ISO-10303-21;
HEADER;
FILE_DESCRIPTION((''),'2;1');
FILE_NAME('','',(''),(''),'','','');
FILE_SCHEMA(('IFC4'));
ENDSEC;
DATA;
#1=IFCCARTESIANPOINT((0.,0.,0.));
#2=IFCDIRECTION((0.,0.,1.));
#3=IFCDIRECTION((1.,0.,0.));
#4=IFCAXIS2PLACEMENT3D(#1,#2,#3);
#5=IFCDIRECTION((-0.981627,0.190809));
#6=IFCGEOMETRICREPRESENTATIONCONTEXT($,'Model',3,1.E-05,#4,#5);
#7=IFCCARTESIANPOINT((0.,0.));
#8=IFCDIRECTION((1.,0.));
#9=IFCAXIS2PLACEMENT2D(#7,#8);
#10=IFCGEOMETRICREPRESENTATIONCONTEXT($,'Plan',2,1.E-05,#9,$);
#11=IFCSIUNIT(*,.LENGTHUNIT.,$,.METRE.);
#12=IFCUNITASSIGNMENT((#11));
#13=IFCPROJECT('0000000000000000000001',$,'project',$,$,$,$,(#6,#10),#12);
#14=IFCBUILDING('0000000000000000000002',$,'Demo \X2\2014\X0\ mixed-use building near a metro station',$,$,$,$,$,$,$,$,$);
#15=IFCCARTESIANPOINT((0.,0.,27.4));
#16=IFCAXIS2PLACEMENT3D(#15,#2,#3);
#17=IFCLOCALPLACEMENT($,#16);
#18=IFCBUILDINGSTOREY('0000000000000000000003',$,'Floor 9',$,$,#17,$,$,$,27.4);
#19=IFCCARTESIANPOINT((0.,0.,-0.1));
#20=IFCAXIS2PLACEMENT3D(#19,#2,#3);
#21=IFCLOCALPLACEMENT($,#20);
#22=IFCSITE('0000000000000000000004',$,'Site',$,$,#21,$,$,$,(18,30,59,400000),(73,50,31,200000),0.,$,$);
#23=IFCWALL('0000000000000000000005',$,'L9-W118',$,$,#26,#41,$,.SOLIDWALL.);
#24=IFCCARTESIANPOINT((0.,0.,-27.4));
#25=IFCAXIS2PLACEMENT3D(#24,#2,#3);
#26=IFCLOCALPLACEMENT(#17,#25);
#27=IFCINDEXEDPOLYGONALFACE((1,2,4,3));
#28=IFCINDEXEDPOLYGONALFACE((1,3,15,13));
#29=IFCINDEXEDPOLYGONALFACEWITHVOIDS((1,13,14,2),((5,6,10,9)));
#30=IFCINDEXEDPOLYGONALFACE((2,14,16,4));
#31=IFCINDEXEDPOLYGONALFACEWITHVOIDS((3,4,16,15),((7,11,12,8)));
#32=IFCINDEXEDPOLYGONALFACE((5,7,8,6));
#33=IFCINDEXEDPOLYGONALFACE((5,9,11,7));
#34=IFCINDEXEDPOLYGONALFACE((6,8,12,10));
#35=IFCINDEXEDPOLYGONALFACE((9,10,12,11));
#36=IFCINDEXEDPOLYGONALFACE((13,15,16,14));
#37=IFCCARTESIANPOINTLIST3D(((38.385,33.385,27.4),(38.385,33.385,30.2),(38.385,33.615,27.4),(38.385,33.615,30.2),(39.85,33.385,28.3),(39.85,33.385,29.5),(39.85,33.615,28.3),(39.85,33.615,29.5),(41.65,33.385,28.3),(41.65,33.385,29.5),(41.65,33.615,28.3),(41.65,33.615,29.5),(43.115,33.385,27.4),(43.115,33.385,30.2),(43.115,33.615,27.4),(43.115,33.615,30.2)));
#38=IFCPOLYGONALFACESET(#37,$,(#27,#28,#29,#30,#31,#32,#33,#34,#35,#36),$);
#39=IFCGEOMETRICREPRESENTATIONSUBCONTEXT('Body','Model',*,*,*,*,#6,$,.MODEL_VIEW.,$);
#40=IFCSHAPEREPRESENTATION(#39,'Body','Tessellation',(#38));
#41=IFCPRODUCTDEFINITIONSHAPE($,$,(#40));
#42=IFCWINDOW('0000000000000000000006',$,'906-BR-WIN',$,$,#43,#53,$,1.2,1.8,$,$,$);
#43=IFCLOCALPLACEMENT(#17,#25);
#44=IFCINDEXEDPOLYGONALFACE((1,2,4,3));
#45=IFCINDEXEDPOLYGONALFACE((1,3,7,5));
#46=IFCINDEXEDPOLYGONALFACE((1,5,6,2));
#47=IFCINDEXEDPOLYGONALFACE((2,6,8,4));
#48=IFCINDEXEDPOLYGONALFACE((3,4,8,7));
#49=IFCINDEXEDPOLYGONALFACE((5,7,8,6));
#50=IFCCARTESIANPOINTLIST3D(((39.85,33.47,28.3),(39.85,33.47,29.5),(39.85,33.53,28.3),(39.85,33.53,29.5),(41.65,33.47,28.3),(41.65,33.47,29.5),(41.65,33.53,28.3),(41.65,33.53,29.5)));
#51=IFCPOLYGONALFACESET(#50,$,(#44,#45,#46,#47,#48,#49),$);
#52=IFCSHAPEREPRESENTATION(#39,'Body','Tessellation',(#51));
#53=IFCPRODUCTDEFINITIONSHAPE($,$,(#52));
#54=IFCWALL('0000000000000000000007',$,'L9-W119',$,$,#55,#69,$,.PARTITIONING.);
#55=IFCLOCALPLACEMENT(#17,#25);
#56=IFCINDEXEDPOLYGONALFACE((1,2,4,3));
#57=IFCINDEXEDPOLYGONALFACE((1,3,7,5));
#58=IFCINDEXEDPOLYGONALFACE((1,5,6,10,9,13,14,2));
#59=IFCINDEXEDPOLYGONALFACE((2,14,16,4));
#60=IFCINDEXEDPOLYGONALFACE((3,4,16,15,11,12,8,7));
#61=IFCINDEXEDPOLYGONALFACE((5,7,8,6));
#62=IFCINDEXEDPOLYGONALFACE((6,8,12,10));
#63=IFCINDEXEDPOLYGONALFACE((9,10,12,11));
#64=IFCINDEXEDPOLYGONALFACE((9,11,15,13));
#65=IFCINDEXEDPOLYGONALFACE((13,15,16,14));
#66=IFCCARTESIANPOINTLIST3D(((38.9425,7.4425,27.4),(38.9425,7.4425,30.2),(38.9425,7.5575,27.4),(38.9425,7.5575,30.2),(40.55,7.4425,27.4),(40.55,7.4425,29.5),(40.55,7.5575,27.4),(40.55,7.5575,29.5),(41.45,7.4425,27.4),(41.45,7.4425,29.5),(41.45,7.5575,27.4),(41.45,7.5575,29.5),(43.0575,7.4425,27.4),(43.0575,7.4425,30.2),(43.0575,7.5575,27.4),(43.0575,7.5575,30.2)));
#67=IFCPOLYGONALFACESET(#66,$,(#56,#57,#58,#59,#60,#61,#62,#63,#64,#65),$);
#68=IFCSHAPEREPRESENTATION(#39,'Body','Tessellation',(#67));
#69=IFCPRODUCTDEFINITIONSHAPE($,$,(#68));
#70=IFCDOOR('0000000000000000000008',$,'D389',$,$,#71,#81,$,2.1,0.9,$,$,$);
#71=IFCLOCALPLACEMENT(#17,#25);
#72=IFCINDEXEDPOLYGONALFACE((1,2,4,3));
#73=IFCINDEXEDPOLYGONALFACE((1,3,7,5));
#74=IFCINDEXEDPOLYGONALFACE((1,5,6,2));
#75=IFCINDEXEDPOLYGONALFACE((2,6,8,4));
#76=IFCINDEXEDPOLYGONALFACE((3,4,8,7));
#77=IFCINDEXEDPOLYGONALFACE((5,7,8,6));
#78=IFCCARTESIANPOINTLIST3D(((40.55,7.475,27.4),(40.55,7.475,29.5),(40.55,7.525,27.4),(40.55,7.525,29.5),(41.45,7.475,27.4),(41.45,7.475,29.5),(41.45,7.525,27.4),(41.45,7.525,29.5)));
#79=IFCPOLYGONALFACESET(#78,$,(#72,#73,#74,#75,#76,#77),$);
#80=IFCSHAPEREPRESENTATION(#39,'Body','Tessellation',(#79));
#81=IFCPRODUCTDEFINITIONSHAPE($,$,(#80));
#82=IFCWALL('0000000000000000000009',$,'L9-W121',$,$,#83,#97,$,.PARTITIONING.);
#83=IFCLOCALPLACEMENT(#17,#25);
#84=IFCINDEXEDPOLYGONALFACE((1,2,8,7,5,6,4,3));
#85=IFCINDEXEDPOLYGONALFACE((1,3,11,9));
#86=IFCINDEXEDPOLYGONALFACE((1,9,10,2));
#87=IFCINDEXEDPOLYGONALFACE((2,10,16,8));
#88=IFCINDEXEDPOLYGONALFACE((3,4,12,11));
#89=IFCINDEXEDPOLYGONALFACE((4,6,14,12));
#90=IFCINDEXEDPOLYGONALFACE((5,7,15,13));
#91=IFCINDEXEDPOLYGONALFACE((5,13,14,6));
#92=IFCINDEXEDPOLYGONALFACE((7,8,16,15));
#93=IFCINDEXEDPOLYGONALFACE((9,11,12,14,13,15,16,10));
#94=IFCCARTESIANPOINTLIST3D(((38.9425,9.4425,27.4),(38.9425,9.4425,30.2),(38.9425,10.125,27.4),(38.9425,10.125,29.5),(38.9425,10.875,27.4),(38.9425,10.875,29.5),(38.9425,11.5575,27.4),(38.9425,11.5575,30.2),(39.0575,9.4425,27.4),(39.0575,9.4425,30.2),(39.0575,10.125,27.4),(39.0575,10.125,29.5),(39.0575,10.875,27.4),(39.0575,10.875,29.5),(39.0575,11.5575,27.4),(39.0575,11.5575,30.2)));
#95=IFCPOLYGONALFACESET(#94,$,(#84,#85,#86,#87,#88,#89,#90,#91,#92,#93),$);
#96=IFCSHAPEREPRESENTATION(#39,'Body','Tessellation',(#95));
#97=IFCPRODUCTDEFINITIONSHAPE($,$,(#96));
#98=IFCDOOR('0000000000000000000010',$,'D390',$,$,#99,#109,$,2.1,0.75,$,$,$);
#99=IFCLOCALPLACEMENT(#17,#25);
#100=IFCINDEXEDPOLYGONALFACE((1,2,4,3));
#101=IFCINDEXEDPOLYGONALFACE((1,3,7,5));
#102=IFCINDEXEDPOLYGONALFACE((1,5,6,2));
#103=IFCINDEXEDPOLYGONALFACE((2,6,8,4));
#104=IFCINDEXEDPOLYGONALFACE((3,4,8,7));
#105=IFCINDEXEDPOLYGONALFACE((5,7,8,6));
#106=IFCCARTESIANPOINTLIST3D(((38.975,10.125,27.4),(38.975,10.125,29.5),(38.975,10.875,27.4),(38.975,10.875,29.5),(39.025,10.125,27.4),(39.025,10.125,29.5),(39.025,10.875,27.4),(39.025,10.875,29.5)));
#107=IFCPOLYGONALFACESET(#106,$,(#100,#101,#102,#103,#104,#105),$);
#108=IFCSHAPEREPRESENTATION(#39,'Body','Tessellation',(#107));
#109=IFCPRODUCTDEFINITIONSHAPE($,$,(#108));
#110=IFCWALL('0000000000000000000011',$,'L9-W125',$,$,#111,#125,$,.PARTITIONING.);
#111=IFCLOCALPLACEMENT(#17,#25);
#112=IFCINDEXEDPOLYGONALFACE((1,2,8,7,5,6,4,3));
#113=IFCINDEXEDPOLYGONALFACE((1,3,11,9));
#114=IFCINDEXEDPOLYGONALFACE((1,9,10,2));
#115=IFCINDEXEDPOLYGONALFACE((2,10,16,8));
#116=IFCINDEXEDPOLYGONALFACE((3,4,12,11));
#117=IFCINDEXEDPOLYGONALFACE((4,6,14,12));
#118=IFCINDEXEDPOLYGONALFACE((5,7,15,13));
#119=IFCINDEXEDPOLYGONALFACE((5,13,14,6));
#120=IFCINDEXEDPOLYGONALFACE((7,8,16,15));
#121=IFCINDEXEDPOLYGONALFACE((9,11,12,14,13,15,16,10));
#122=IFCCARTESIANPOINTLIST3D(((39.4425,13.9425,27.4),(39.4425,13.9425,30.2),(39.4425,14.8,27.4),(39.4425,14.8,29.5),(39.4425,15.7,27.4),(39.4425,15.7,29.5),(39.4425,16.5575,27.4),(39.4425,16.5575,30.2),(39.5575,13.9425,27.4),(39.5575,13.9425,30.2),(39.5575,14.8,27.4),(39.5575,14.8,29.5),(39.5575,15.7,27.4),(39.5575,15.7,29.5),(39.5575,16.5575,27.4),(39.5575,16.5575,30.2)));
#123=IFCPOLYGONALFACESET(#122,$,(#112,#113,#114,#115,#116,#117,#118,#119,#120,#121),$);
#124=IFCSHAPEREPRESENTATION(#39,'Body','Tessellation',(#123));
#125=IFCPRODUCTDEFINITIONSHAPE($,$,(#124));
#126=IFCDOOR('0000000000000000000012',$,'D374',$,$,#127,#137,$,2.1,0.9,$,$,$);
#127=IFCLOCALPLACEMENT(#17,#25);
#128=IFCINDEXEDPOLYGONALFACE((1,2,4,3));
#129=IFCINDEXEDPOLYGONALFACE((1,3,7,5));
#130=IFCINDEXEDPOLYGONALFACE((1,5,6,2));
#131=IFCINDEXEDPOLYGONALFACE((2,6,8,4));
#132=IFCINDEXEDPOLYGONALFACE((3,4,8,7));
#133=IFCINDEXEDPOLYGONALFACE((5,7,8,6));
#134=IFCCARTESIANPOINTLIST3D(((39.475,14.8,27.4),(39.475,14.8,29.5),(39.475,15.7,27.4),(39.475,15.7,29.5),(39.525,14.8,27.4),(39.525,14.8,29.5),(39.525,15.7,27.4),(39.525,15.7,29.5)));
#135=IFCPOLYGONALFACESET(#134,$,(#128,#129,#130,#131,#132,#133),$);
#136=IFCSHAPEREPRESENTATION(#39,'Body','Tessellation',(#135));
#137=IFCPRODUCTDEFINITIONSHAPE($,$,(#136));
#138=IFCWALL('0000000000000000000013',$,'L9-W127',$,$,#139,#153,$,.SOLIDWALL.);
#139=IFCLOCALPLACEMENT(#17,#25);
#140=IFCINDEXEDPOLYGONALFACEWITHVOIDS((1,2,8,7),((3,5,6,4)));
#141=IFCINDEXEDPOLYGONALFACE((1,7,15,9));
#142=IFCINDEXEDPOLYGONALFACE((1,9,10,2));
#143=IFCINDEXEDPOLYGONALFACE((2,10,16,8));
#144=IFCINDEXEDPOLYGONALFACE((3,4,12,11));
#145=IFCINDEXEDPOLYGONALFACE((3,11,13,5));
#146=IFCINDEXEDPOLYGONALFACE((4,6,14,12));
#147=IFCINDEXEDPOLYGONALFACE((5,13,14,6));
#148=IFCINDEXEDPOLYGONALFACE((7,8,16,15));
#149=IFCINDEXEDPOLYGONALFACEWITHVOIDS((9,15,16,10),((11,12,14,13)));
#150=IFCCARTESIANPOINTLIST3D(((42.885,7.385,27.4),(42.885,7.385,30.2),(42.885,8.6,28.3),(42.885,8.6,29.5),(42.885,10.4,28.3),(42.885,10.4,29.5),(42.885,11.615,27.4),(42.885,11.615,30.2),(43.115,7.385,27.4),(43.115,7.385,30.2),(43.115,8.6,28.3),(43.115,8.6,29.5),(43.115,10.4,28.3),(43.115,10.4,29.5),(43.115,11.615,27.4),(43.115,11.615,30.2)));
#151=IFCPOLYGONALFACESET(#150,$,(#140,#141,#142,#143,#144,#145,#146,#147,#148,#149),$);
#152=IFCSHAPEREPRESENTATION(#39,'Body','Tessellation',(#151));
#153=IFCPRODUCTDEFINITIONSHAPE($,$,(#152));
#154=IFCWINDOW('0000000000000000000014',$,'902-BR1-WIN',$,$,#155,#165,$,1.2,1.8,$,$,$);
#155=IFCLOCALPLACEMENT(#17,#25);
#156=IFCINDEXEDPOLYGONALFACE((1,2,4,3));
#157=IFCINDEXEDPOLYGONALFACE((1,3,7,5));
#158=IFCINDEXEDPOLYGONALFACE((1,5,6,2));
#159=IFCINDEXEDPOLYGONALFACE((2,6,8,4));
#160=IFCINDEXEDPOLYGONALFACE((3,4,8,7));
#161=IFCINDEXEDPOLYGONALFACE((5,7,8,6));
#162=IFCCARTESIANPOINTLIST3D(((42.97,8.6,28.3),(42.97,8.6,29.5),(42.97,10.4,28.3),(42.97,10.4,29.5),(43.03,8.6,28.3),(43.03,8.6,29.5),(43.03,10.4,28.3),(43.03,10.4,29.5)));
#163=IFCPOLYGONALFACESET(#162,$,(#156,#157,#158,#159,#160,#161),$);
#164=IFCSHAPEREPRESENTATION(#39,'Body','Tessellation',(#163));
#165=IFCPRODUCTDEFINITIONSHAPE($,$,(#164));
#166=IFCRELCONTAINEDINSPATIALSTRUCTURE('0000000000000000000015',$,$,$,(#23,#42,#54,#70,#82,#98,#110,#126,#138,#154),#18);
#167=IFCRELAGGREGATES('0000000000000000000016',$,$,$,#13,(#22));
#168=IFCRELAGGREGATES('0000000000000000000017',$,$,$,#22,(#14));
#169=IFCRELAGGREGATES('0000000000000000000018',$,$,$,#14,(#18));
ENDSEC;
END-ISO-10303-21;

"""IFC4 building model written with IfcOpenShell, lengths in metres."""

from ifc_helpers import new_model, si_unit, direction, frame, origin_with_axes, origin_2d_with_axis, place, context, subcontext, project, spatial, line, indexed_curve, outline, extrude, element, fill, save


model = new_model("IFC4")

# Units and contexts
model_context = context("Model", 3, precision=1e-05, world=origin_with_axes(), true_north=direction((-0.981627, 0.190809)))
plan_context = context("Plan", 2, precision=1e-05, world=origin_2d_with_axis())
body_context = subcontext(model_context, "Body", "Model", "MODEL_VIEW")
ifc_project = project(units=[si_unit("LENGTHUNIT", "METRE")], contexts=[model_context, plan_context])

# Site, building, storey
site_placement = place(None, frame((0.0, 0.0, -0.1), z_axis=(0.0, 0.0, 1.0), x_axis=(1.0, 0.0, 0.0)))
site = spatial("IfcSite", under=ifc_project, at=site_placement, Name="Site", RefLatitude=(18, 30, 59, 400000), RefLongitude=(73, 50, 31, 200000), RefElevation=0.0)
building = spatial("IfcBuilding", under=site, Name="Demo — mixed-use building near a metro station")
storey_placement = place(None, frame((0.0, 0.0, 27.4), z_axis=(0.0, 0.0, 1.0), x_axis=(1.0, 0.0, 0.0)))
storey = spatial("IfcBuildingStorey", under=building, at=storey_placement, Name="Floor 9", Elevation=27.4)

# Wall, opening, window
wall_1_placement = place(storey_placement, frame((0.0, 0.0, -27.4), z_axis=(0.0, 0.0, 1.0), x_axis=(1.0, 0.0, 0.0)))
wall_1 = element("IfcWall", 1, at=wall_1_placement, inside=storey, Name="L9-W118", PredefinedType="SOLIDWALL", context=body_context, shape_type="SweptSolid", body=[
    extrude(outline(indexed_curve([(43.115, 33.385), (38.385, 33.385), (38.385, 33.615), (43.115, 33.615)], segments=[line(1, 2, 3, 4, 1)])), frame((0.0, 0.0, 27.4), z_axis=(0.0, 0.0, 1.0), x_axis=(1.0, 0.0, 0.0)), (0.0, 0.0, 1.0), 2.8),
])
opening_1_placement = place(wall_1_placement, origin_with_axes())
opening_1 = element("IfcOpeningElement", 2, at=opening_1_placement, cuts=wall_1, context=body_context, shape_type="SweptSolid", body=[
    extrude(outline(indexed_curve([(41.65, 33.335), (39.85, 33.335), (39.85, 33.665), (41.65, 33.665)], segments=[line(1, 2, 3, 4, 1)])), frame((0.0, 0.0, 28.3), z_axis=(0.0, 0.0, 1.0), x_axis=(1.0, 0.0, 0.0)), (0.0, 0.0, 1.0), 1.2),
])
window_1_placement = place(storey_placement, frame((0.0, 0.0, -27.4), z_axis=(0.0, 0.0, 1.0), x_axis=(1.0, 0.0, 0.0)))
window_1 = element("IfcWindow", 3, at=window_1_placement, inside=storey, Name="906-BR-WIN", OverallHeight=1.2, OverallWidth=1.8, context=body_context, shape_type="SweptSolid", body=[
    extrude(outline(indexed_curve([(41.65, 33.47), (39.85, 33.47), (39.85, 33.53), (41.65, 33.53)], segments=[line(1, 2, 3, 4, 1)])), frame((0.0, 0.0, 28.3), z_axis=(0.0, 0.0, 1.0), x_axis=(1.0, 0.0, 0.0)), (0.0, 0.0, 1.0), 1.2),
])
fill(opening_1, window_1)

# Wall, opening, door
wall_2_placement = place(storey_placement, frame((0.0, 0.0, -27.4), z_axis=(0.0, 0.0, 1.0), x_axis=(1.0, 0.0, 0.0)))
wall_2 = element("IfcWall", 4, at=wall_2_placement, inside=storey, Name="L9-W119", PredefinedType="PARTITIONING", context=body_context, shape_type="SweptSolid", body=[
    extrude(outline(indexed_curve([(43.0575, 7.4425), (38.9425, 7.4425), (38.9425, 7.5575), (43.0575, 7.5575)], segments=[line(1, 2, 3, 4, 1)])), frame((0.0, 0.0, 27.4), z_axis=(0.0, 0.0, 1.0), x_axis=(1.0, 0.0, 0.0)), (0.0, 0.0, 1.0), 2.8),
])
opening_2_placement = place(wall_2_placement, origin_with_axes())
opening_2 = element("IfcOpeningElement", 5, at=opening_2_placement, cuts=wall_2, context=body_context, shape_type="SweptSolid", body=[
    extrude(outline(indexed_curve([(41.45, 7.3925), (40.55, 7.3925), (40.55, 7.6075), (41.45, 7.6075)], segments=[line(1, 2, 3, 4, 1)])), frame((0.0, 0.0, 27.4), z_axis=(0.0, 0.0, 1.0), x_axis=(1.0, 0.0, 0.0)), (0.0, 0.0, 1.0), 2.1),
])
door_1_placement = place(storey_placement, frame((0.0, 0.0, -27.4), z_axis=(0.0, 0.0, 1.0), x_axis=(1.0, 0.0, 0.0)))
door_1 = element("IfcDoor", 6, at=door_1_placement, inside=storey, Name="D389", OverallHeight=2.1, OverallWidth=0.9, context=body_context, shape_type="SweptSolid", body=[
    extrude(outline(indexed_curve([(41.45, 7.475), (40.55, 7.475), (40.55, 7.525), (41.45, 7.525)], segments=[line(1, 2, 3, 4, 1)])), frame((0.0, 0.0, 27.4), z_axis=(0.0, 0.0, 1.0), x_axis=(1.0, 0.0, 0.0)), (0.0, 0.0, 1.0), 2.1),
])
fill(opening_2, door_1)

# Wall, opening, door
wall_3_placement = place(storey_placement, frame((0.0, 0.0, -27.4), z_axis=(0.0, 0.0, 1.0), x_axis=(1.0, 0.0, 0.0)))
wall_3 = element("IfcWall", 7, at=wall_3_placement, inside=storey, Name="L9-W121", PredefinedType="PARTITIONING", context=body_context, shape_type="SweptSolid", body=[
    extrude(outline(indexed_curve([(39.0575, 11.5575), (39.0575, 9.4425), (38.9425, 9.4425), (38.9425, 11.5575)], segments=[line(1, 2, 3, 4, 1)])), frame((0.0, 0.0, 27.4), z_axis=(0.0, 0.0, 1.0), x_axis=(1.0, 0.0, 0.0)), (0.0, 0.0, 1.0), 2.8),
])
opening_3_placement = place(wall_3_placement, origin_with_axes())
opening_3 = element("IfcOpeningElement", 8, at=opening_3_placement, cuts=wall_3, context=body_context, shape_type="SweptSolid", body=[
    extrude(outline(indexed_curve([(39.1075, 10.875), (39.1075, 10.125), (38.8925, 10.125), (38.8925, 10.875)], segments=[line(1, 2, 3, 4, 1)])), frame((0.0, 0.0, 27.4), z_axis=(0.0, 0.0, 1.0), x_axis=(1.0, 0.0, 0.0)), (0.0, 0.0, 1.0), 2.1),
])
door_2_placement = place(storey_placement, frame((0.0, 0.0, -27.4), z_axis=(0.0, 0.0, 1.0), x_axis=(1.0, 0.0, 0.0)))
door_2 = element("IfcDoor", 9, at=door_2_placement, inside=storey, Name="D390", OverallHeight=2.1, OverallWidth=0.75, context=body_context, shape_type="SweptSolid", body=[
    extrude(outline(indexed_curve([(39.025, 10.875), (39.025, 10.125), (38.975, 10.125), (38.975, 10.875)], segments=[line(1, 2, 3, 4, 1)])), frame((0.0, 0.0, 27.4), z_axis=(0.0, 0.0, 1.0), x_axis=(1.0, 0.0, 0.0)), (0.0, 0.0, 1.0), 2.1),
])
fill(opening_3, door_2)

# Wall, opening, door
wall_4_placement = place(storey_placement, frame((0.0, 0.0, -27.4), z_axis=(0.0, 0.0, 1.0), x_axis=(1.0, 0.0, 0.0)))
wall_4 = element("IfcWall", 10, at=wall_4_placement, inside=storey, Name="L9-W125", PredefinedType="PARTITIONING", context=body_context, shape_type="SweptSolid", body=[
    extrude(outline(indexed_curve([(39.4425, 13.9425), (39.4425, 16.5575), (39.5575, 16.5575), (39.5575, 13.9425)], segments=[line(1, 2, 3, 4, 1)])), frame((0.0, 0.0, 27.4), z_axis=(0.0, 0.0, 1.0), x_axis=(1.0, 0.0, 0.0)), (0.0, 0.0, 1.0), 2.8),
])
opening_4_placement = place(wall_4_placement, origin_with_axes())
opening_4 = element("IfcOpeningElement", 11, at=opening_4_placement, cuts=wall_4, context=body_context, shape_type="SweptSolid", body=[
    extrude(outline(indexed_curve([(39.3925, 14.8), (39.3925, 15.7), (39.6075, 15.7), (39.6075, 14.8)], segments=[line(1, 2, 3, 4, 1)])), frame((0.0, 0.0, 27.4), z_axis=(0.0, 0.0, 1.0), x_axis=(1.0, 0.0, 0.0)), (0.0, 0.0, 1.0), 2.1),
])
door_3_placement = place(storey_placement, frame((0.0, 0.0, -27.4), z_axis=(0.0, 0.0, 1.0), x_axis=(1.0, 0.0, 0.0)))
door_3 = element("IfcDoor", 12, at=door_3_placement, inside=storey, Name="D374", OverallHeight=2.1, OverallWidth=0.9, context=body_context, shape_type="SweptSolid", body=[
    extrude(outline(indexed_curve([(39.475, 14.8), (39.475, 15.7), (39.525, 15.7), (39.525, 14.8)], segments=[line(1, 2, 3, 4, 1)])), frame((0.0, 0.0, 27.4), z_axis=(0.0, 0.0, 1.0), x_axis=(1.0, 0.0, 0.0)), (0.0, 0.0, 1.0), 2.1),
])
fill(opening_4, door_3)

# Wall, opening, window
wall_5_placement = place(storey_placement, frame((0.0, 0.0, -27.4), z_axis=(0.0, 0.0, 1.0), x_axis=(1.0, 0.0, 0.0)))
wall_5 = element("IfcWall", 13, at=wall_5_placement, inside=storey, Name="L9-W127", PredefinedType="SOLIDWALL", context=body_context, shape_type="SweptSolid", body=[
    extrude(outline(indexed_curve([(42.885, 7.385), (42.885, 11.615), (43.115, 11.615), (43.115, 7.385)], segments=[line(1, 2, 3, 4, 1)])), frame((0.0, 0.0, 27.4), z_axis=(0.0, 0.0, 1.0), x_axis=(1.0, 0.0, 0.0)), (0.0, 0.0, 1.0), 2.8),
])
opening_5_placement = place(wall_5_placement, origin_with_axes())
opening_5 = element("IfcOpeningElement", 14, at=opening_5_placement, cuts=wall_5, context=body_context, shape_type="SweptSolid", body=[
    extrude(outline(indexed_curve([(42.835, 8.6), (42.835, 10.4), (43.165, 10.4), (43.165, 8.6)], segments=[line(1, 2, 3, 4, 1)])), frame((0.0, 0.0, 28.3), z_axis=(0.0, 0.0, 1.0), x_axis=(1.0, 0.0, 0.0)), (0.0, 0.0, 1.0), 1.2),
])
window_2_placement = place(storey_placement, frame((0.0, 0.0, -27.4), z_axis=(0.0, 0.0, 1.0), x_axis=(1.0, 0.0, 0.0)))
window_2 = element("IfcWindow", 15, at=window_2_placement, inside=storey, Name="902-BR1-WIN", OverallHeight=1.2, OverallWidth=1.8, context=body_context, shape_type="SweptSolid", body=[
    extrude(outline(indexed_curve([(42.97, 8.6), (42.97, 10.4), (43.03, 10.4), (43.03, 8.6)], segments=[line(1, 2, 3, 4, 1)])), frame((0.0, 0.0, 28.3), z_axis=(0.0, 0.0, 1.0), x_axis=(1.0, 0.0, 0.0)), (0.0, 0.0, 1.0), 1.2),
])
fill(opening_5, window_2)

save(model, "model.ifc")
